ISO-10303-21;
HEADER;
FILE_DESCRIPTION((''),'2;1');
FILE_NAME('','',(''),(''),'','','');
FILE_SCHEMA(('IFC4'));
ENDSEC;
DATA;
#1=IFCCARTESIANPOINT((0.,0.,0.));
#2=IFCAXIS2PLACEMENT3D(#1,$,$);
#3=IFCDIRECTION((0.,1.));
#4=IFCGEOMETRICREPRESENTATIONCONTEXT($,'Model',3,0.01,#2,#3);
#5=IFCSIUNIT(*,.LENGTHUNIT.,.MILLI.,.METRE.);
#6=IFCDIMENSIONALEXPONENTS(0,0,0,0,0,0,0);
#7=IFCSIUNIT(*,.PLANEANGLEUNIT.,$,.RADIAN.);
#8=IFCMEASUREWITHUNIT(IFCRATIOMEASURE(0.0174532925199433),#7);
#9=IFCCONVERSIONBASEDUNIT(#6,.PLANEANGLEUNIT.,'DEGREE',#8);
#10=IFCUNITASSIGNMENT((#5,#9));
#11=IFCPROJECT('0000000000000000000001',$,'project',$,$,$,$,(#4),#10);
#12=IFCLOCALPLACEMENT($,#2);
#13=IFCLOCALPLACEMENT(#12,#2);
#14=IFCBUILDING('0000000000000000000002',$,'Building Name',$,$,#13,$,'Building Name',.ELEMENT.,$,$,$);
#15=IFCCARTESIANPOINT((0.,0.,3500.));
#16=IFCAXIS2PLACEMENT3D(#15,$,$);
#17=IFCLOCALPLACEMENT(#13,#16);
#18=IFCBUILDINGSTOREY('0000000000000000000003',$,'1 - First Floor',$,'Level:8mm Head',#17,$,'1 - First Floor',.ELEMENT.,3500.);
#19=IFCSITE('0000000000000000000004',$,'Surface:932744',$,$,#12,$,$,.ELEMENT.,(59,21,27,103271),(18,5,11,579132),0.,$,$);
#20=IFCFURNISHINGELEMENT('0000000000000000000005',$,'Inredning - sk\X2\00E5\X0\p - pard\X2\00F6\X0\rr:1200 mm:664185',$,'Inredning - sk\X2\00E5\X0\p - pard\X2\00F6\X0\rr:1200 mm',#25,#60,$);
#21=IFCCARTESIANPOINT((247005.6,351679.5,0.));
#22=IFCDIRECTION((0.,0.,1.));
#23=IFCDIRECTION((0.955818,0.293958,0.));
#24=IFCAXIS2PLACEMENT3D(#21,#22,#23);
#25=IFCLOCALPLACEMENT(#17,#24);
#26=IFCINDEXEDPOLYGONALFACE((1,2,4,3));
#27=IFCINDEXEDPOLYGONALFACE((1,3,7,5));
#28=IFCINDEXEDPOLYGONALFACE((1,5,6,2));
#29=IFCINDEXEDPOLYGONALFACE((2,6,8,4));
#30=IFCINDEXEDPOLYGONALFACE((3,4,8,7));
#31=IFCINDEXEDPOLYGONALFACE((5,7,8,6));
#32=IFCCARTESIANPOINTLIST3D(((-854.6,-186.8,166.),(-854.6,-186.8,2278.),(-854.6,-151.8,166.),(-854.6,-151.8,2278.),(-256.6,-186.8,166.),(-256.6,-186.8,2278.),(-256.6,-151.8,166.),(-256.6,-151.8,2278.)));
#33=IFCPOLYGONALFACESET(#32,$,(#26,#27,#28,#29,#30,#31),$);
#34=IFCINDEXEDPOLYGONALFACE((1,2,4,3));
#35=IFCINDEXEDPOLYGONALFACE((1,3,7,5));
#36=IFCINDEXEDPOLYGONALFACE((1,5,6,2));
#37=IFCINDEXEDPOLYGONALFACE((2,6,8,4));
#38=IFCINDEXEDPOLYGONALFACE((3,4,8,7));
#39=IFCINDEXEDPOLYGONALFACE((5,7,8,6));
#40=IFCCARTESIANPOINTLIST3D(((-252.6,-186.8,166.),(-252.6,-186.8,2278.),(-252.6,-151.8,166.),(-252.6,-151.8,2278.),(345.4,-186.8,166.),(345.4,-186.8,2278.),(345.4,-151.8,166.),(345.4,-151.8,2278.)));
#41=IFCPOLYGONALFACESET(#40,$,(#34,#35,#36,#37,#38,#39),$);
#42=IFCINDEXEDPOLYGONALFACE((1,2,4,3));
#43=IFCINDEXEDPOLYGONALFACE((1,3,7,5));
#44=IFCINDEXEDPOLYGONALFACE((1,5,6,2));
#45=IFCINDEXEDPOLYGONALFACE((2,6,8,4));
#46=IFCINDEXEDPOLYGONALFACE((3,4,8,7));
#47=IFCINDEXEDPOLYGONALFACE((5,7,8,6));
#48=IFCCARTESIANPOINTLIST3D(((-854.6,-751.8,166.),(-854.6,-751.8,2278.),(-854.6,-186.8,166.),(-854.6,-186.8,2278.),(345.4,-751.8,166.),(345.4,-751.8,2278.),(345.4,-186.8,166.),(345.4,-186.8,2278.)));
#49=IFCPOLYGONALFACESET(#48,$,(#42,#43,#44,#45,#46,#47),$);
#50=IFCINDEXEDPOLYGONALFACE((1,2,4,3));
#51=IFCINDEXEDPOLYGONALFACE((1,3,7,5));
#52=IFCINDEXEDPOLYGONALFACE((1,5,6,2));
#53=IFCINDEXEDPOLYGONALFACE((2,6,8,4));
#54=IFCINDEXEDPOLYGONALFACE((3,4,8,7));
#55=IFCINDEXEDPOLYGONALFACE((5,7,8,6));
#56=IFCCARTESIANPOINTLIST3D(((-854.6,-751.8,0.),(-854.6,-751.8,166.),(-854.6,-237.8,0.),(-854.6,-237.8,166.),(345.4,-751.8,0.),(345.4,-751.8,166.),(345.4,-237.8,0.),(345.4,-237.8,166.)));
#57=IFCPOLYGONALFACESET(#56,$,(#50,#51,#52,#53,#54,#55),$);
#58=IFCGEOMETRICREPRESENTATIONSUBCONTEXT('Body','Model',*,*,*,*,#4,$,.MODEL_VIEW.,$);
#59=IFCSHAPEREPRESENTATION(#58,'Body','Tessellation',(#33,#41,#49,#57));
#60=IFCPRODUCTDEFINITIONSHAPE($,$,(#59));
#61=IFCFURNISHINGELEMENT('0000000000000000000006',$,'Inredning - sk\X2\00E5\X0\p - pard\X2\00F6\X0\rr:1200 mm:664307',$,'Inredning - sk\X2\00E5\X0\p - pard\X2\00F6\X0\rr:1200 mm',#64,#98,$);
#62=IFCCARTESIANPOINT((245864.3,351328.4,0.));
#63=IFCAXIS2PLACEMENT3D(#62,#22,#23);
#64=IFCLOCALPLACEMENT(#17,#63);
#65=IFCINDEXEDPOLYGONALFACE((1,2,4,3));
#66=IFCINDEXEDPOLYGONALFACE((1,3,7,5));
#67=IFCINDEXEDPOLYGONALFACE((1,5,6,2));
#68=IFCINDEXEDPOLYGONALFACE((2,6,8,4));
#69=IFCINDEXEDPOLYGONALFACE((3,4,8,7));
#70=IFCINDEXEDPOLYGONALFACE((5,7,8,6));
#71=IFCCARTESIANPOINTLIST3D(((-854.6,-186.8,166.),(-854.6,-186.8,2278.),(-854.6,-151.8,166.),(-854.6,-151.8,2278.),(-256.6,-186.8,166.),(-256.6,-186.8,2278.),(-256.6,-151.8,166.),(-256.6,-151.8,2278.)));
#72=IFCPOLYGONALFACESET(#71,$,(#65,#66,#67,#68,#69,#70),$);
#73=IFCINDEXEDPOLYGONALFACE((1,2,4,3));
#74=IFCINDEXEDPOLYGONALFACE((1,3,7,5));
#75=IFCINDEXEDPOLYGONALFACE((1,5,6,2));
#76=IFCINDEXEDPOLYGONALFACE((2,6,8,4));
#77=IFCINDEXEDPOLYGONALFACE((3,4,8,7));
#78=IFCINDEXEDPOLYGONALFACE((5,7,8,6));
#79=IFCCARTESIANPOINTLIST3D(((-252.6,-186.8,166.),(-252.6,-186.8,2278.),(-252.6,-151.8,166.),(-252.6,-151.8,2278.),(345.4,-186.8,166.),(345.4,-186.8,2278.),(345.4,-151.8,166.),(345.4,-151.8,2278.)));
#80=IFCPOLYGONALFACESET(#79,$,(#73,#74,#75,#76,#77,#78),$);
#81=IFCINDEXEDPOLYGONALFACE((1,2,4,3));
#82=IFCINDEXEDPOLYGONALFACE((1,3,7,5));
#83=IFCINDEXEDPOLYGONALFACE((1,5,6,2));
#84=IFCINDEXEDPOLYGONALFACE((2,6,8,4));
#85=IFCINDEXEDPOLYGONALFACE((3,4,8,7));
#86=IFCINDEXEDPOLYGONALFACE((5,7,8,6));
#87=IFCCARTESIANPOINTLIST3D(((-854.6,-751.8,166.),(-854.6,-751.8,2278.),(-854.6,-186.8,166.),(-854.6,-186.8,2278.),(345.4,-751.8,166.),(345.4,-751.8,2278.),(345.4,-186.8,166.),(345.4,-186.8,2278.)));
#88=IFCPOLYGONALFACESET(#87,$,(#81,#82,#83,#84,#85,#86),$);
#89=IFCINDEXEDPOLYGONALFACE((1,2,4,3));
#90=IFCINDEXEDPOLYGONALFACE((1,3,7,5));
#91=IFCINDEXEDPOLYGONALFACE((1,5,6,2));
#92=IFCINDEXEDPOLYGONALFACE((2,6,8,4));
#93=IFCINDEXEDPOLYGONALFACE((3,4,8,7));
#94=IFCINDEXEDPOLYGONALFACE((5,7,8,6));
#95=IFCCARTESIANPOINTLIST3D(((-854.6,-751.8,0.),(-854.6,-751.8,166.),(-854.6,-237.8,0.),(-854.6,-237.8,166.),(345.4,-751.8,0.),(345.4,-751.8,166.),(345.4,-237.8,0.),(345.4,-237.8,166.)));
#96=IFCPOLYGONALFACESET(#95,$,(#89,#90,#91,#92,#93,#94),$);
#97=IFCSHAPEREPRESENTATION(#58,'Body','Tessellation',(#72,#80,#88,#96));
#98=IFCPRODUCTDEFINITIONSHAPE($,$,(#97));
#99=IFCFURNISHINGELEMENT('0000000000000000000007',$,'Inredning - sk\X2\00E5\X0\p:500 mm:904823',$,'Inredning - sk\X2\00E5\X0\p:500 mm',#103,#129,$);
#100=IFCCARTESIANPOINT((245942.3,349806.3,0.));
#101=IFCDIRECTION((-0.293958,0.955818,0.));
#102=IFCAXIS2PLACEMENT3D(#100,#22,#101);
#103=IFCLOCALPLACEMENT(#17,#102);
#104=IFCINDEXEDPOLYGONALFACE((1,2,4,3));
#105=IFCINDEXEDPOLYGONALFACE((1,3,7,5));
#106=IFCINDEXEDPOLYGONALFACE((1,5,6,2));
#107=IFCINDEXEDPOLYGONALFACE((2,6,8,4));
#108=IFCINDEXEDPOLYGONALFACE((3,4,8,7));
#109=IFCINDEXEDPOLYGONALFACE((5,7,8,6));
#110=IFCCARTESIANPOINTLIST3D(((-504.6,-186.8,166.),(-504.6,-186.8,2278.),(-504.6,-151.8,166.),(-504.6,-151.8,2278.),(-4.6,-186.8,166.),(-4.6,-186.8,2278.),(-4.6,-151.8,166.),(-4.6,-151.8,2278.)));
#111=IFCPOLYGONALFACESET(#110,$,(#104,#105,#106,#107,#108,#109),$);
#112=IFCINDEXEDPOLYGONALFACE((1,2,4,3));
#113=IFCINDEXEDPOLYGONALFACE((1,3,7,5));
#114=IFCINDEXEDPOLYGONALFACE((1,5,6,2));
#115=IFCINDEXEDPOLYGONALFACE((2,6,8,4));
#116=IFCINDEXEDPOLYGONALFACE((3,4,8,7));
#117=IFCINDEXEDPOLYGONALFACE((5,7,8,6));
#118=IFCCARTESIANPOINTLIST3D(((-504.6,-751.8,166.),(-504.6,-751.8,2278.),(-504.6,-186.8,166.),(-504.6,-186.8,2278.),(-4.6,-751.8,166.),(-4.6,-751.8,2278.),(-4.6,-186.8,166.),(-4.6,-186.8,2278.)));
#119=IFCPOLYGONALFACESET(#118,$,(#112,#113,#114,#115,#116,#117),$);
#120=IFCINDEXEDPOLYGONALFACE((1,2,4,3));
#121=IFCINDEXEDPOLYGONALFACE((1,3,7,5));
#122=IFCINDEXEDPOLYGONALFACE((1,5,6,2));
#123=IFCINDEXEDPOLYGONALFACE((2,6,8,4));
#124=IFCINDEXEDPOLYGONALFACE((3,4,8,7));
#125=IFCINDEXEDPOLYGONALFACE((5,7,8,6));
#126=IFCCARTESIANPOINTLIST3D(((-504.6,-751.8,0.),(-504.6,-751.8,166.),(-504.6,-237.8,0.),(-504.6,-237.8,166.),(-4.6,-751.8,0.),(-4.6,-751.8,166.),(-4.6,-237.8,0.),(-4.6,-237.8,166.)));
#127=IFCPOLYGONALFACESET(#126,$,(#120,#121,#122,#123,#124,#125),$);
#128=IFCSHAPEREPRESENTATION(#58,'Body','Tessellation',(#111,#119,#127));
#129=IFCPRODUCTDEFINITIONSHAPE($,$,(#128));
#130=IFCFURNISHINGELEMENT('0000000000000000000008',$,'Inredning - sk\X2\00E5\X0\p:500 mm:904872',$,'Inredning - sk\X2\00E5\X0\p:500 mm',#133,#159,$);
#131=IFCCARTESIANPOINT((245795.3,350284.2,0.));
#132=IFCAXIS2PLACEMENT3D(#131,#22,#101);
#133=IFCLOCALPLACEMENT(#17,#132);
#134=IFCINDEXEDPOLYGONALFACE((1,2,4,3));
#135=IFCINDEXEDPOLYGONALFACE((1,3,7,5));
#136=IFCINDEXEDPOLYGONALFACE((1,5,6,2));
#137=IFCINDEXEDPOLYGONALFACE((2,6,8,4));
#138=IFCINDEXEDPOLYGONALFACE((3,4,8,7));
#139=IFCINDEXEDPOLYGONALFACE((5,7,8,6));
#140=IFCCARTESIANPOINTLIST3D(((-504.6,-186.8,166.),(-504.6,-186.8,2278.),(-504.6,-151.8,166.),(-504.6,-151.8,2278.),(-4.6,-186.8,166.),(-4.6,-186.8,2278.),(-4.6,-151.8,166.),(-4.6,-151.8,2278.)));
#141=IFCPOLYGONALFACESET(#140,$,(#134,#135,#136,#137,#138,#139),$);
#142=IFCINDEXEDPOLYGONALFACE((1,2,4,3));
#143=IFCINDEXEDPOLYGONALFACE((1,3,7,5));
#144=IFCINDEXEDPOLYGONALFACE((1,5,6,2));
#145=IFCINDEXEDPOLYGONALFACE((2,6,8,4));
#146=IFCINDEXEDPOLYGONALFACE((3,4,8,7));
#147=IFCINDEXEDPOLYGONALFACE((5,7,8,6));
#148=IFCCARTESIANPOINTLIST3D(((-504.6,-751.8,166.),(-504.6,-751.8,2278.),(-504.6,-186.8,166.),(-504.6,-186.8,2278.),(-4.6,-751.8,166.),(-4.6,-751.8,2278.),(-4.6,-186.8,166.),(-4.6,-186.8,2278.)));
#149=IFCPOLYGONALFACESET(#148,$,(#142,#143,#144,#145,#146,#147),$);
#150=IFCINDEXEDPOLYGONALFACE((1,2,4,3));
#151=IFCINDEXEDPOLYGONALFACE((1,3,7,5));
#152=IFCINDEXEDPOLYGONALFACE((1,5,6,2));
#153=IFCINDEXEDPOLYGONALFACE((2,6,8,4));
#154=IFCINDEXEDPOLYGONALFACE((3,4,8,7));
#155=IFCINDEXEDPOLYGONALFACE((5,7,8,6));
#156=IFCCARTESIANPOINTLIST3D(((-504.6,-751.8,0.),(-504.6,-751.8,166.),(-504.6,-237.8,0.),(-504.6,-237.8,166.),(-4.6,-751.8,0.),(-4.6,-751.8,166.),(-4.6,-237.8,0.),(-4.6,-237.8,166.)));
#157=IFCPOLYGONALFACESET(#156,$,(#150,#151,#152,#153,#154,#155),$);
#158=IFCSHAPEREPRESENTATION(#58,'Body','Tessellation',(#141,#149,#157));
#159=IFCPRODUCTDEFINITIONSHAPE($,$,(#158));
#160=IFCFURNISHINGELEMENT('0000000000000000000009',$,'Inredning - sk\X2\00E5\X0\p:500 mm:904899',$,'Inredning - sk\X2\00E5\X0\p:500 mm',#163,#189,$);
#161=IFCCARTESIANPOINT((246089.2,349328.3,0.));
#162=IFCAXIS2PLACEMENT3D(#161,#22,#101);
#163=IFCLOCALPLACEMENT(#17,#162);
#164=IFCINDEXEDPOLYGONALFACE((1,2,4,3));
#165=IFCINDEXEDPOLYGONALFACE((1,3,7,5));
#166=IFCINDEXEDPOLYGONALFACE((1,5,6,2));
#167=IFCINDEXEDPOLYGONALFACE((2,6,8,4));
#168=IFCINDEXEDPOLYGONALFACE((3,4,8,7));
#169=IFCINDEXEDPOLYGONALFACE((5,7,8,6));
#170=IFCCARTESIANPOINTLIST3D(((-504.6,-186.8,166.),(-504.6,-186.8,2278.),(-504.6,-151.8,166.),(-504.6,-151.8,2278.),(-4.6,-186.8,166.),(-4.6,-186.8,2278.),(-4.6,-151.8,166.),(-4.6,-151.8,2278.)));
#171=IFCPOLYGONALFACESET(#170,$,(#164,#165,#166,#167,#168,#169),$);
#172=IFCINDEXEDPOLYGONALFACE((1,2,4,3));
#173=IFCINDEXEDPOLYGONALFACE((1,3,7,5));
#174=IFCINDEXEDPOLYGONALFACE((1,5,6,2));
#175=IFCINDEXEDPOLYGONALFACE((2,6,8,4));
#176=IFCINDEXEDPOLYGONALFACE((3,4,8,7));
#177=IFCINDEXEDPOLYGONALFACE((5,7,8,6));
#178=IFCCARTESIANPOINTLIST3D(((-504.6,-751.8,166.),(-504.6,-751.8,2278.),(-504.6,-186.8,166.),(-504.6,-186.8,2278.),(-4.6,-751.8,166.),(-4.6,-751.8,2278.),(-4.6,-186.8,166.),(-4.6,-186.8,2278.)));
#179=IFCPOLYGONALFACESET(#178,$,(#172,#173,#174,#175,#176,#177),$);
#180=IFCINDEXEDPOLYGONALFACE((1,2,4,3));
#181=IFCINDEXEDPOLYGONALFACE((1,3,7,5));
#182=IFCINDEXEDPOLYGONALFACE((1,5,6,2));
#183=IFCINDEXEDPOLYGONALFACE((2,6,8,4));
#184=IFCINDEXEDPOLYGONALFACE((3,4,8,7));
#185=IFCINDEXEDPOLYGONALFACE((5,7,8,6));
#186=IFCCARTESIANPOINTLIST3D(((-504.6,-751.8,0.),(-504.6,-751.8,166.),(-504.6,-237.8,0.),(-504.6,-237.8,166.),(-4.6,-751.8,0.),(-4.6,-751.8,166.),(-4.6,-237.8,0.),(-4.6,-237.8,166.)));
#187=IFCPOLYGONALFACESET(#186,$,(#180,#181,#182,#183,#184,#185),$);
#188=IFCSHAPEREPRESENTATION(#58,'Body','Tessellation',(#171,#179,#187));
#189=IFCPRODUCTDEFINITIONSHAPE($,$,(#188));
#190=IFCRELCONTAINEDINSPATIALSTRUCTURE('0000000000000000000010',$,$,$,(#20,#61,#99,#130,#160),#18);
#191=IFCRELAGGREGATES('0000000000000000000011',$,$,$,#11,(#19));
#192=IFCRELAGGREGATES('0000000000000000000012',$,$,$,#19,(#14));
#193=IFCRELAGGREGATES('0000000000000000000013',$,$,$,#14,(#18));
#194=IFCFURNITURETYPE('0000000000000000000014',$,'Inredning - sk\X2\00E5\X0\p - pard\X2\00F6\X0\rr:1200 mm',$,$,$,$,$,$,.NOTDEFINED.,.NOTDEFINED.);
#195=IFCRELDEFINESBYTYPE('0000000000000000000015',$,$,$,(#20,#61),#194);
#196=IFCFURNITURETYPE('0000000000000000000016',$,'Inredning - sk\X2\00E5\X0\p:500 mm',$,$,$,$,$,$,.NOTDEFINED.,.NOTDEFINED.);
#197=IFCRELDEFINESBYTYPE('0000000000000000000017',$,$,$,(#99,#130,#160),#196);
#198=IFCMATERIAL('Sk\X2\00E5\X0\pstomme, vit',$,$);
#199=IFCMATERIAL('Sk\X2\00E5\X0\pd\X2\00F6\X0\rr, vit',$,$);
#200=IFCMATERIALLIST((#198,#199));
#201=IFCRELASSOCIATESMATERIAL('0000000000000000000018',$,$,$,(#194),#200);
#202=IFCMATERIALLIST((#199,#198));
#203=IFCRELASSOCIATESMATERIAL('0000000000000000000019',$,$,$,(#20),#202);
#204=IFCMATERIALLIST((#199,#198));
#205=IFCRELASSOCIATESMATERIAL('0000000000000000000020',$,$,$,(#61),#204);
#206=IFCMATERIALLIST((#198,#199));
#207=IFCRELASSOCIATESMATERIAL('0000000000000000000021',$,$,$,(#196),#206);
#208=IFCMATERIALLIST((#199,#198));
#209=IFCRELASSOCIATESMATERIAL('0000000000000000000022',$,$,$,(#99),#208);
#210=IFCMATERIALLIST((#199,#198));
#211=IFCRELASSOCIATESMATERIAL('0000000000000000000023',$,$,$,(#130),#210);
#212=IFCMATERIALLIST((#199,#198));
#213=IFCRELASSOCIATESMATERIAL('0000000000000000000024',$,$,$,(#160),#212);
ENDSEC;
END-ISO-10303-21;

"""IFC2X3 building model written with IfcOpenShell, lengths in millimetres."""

from ifc_helpers import new_model, entity, si_unit, converted_unit, direction, frame, frame_2d, origin, origin_2d_with_axis, place, context, subcontext, project, spatial, rectangle, extrude, source, transform, mapped, material, material_list, type_object, type_shapes, element, save


model = new_model("IFC2X3")

# Units and contexts
model_context = context("Model", 3, precision=0.01, world=origin(), true_north=direction((0.0, 1.0)))
body_context = subcontext(model_context, "Body", "Model", "MODEL_VIEW")
ifc_project = project(units=[si_unit("LENGTHUNIT", "METRE", prefix="MILLI"), converted_unit("PLANEANGLEUNIT", "DEGREE", entity("IfcRatioMeasure", 0.0174532925199433), si_unit("PLANEANGLEUNIT", "RADIAN"), dimensions=[0, 0, 0, 0, 0, 0, 0])], contexts=[model_context])

# Site, building, storey
site_placement = place(None, origin())
site = spatial("IfcSite", under=ifc_project, at=site_placement, Name="Surface:932744", CompositionType="ELEMENT", RefLatitude=(59, 21, 27, 103271), RefLongitude=(18, 5, 11, 579132), RefElevation=0.0)
building_placement = place(site_placement, origin())
building = spatial("IfcBuilding", under=site, at=building_placement, Name="Building Name", LongName="Building Name", CompositionType="ELEMENT")
storey_placement = place(building_placement, frame((0.0, 0.0, 3500.0)))
storey = spatial("IfcBuildingStorey", under=building, at=storey_placement, Name="1 - First Floor", ObjectType="Level:8mm Head", LongName="1 - First Floor", CompositionType="ELEMENT", Elevation=3500.0)

# Furnishing elements
ifc_material_1 = material(Name="Skåpdörr, vit")
ifc_material_2 = material(Name="Skåpstomme, vit")
ifc_material_list_1 = material_list([ifc_material_1, ifc_material_2])
ifc_material_list_2 = material_list([ifc_material_2, ifc_material_1])
furniture_type_1 = type_object("IfcFurnitureType", Name="Inredning - skåp - pardörr:1200 mm", material=ifc_material_list_2)
shared_shape_1 = source(origin(), body_context, "Body", "SweptSolid", [
    extrude(rectangle(XDim=598.0, YDim=35.0, at=origin_2d_with_axis()), frame((-555.6, -169.3, 166.0)), (0.0, 0.0, 1.0), 2112.0),
    extrude(rectangle(XDim=598.0, YDim=35.0, at=frame_2d((0.0, 0.0), x_axis=(1.0, 0.0))), frame((46.4, -169.3, 166.0)), (0.0, 0.0, 1.0), 2112.0),
    extrude(rectangle(XDim=565.0, YDim=1200.0, at=origin_2d_with_axis()), frame((-254.6, -469.3, 166.0), z_axis=(0.0, 0.0, 1.0), x_axis=(0.0, 1.0, 0.0)), (0.0, 0.0, 1.0), 2112.0),
    extrude(rectangle(XDim=514.0, YDim=1200.0, at=origin_2d_with_axis()), frame((-254.6, -494.8, 0.0), z_axis=(0.0, 0.0, 1.0), x_axis=(0.0, 1.0, 0.0)), (0.0, 0.0, 1.0), 166.0),
])
type_shapes(furniture_type_1, [shared_shape_1])
furnishing_1_placement = place(storey_placement, frame((247005.6, 351679.5, 0.0), z_axis=(0.0, 0.0, 1.0), x_axis=(0.955818, 0.293958, 0.0)))
element("IfcFurnishingElement", 1, at=furnishing_1_placement, inside=storey, type_object=furniture_type_1, material=ifc_material_list_1, Name="Inredning - skåp - pardörr:1200 mm:664185", ObjectType="Inredning - skåp - pardörr:1200 mm", context=body_context, shape_type="MappedRepresentation", body=[
    mapped(shared_shape_1, transform((0.0, 0.0, 0.0), scale=1.0)),
])
ifc_material_list_3 = material_list([ifc_material_1, ifc_material_2])
furnishing_2_placement = place(storey_placement, frame((245864.3, 351328.4, 0.0), z_axis=(0.0, 0.0, 1.0), x_axis=(0.955818, 0.293958, 0.0)))
element("IfcFurnishingElement", 2, at=furnishing_2_placement, inside=storey, type_object=furniture_type_1, material=ifc_material_list_3, Name="Inredning - skåp - pardörr:1200 mm:664307", ObjectType="Inredning - skåp - pardörr:1200 mm", context=body_context, shape_type="MappedRepresentation", body=[
    mapped(shared_shape_1, transform((0.0, 0.0, 0.0), scale=1.0)),
])
ifc_material_list_4 = material_list([ifc_material_1, ifc_material_2])
ifc_material_list_5 = material_list([ifc_material_2, ifc_material_1])
furniture_type_2 = type_object("IfcFurnitureType", Name="Inredning - skåp:500 mm", material=ifc_material_list_5)
shared_shape_2 = source(origin(), body_context, "Body", "SweptSolid", [
    extrude(rectangle(XDim=500.0, YDim=35.0, at=frame_2d((0.0, 0.0), x_axis=(1.0, 0.0))), frame((-254.6, -169.3, 166.0)), (0.0, 0.0, 1.0), 2112.0),
    extrude(rectangle(XDim=565.0, YDim=500.0, at=frame_2d((0.0, 0.0), x_axis=(1.0, 0.0))), frame((-254.6, -469.3, 166.0), z_axis=(0.0, 0.0, 1.0), x_axis=(0.0, 1.0, 0.0)), (0.0, 0.0, 1.0), 2112.0),
    extrude(rectangle(XDim=514.0, YDim=500.0, at=origin_2d_with_axis()), frame((-254.6, -494.8, 0.0), z_axis=(0.0, 0.0, 1.0), x_axis=(0.0, 1.0, 0.0)), (0.0, 0.0, 1.0), 166.0),
])
type_shapes(furniture_type_2, [shared_shape_2])
furnishing_3_placement = place(storey_placement, frame((245942.3, 349806.3, 0.0), z_axis=(0.0, 0.0, 1.0), x_axis=(-0.293958, 0.955818, 0.0)))
element("IfcFurnishingElement", 3, at=furnishing_3_placement, inside=storey, type_object=furniture_type_2, material=ifc_material_list_4, Name="Inredning - skåp:500 mm:904823", ObjectType="Inredning - skåp:500 mm", context=body_context, shape_type="MappedRepresentation", body=[
    mapped(shared_shape_2, transform((0.0, 0.0, 0.0), scale=1.0)),
])
ifc_material_list_6 = material_list([ifc_material_1, ifc_material_2])
furnishing_4_placement = place(storey_placement, frame((245795.3, 350284.2, 0.0), z_axis=(0.0, 0.0, 1.0), x_axis=(-0.293958, 0.955818, 0.0)))
element("IfcFurnishingElement", 4, at=furnishing_4_placement, inside=storey, type_object=furniture_type_2, material=ifc_material_list_6, Name="Inredning - skåp:500 mm:904872", ObjectType="Inredning - skåp:500 mm", context=body_context, shape_type="MappedRepresentation", body=[
    mapped(shared_shape_2, transform((0.0, 0.0, 0.0), scale=1.0)),
])
ifc_material_list_7 = material_list([ifc_material_1, ifc_material_2])
furnishing_5_placement = place(storey_placement, frame((246089.2, 349328.3, 0.0), z_axis=(0.0, 0.0, 1.0), x_axis=(-0.293958, 0.955818, 0.0)))
element("IfcFurnishingElement", 5, at=furnishing_5_placement, inside=storey, type_object=furniture_type_2, material=ifc_material_list_7, Name="Inredning - skåp:500 mm:904899", ObjectType="Inredning - skåp:500 mm", context=body_context, shape_type="MappedRepresentation", body=[
    mapped(shared_shape_2, transform((0.0, 0.0, 0.0), scale=1.0)),
])

save(model, "model.ifc")
